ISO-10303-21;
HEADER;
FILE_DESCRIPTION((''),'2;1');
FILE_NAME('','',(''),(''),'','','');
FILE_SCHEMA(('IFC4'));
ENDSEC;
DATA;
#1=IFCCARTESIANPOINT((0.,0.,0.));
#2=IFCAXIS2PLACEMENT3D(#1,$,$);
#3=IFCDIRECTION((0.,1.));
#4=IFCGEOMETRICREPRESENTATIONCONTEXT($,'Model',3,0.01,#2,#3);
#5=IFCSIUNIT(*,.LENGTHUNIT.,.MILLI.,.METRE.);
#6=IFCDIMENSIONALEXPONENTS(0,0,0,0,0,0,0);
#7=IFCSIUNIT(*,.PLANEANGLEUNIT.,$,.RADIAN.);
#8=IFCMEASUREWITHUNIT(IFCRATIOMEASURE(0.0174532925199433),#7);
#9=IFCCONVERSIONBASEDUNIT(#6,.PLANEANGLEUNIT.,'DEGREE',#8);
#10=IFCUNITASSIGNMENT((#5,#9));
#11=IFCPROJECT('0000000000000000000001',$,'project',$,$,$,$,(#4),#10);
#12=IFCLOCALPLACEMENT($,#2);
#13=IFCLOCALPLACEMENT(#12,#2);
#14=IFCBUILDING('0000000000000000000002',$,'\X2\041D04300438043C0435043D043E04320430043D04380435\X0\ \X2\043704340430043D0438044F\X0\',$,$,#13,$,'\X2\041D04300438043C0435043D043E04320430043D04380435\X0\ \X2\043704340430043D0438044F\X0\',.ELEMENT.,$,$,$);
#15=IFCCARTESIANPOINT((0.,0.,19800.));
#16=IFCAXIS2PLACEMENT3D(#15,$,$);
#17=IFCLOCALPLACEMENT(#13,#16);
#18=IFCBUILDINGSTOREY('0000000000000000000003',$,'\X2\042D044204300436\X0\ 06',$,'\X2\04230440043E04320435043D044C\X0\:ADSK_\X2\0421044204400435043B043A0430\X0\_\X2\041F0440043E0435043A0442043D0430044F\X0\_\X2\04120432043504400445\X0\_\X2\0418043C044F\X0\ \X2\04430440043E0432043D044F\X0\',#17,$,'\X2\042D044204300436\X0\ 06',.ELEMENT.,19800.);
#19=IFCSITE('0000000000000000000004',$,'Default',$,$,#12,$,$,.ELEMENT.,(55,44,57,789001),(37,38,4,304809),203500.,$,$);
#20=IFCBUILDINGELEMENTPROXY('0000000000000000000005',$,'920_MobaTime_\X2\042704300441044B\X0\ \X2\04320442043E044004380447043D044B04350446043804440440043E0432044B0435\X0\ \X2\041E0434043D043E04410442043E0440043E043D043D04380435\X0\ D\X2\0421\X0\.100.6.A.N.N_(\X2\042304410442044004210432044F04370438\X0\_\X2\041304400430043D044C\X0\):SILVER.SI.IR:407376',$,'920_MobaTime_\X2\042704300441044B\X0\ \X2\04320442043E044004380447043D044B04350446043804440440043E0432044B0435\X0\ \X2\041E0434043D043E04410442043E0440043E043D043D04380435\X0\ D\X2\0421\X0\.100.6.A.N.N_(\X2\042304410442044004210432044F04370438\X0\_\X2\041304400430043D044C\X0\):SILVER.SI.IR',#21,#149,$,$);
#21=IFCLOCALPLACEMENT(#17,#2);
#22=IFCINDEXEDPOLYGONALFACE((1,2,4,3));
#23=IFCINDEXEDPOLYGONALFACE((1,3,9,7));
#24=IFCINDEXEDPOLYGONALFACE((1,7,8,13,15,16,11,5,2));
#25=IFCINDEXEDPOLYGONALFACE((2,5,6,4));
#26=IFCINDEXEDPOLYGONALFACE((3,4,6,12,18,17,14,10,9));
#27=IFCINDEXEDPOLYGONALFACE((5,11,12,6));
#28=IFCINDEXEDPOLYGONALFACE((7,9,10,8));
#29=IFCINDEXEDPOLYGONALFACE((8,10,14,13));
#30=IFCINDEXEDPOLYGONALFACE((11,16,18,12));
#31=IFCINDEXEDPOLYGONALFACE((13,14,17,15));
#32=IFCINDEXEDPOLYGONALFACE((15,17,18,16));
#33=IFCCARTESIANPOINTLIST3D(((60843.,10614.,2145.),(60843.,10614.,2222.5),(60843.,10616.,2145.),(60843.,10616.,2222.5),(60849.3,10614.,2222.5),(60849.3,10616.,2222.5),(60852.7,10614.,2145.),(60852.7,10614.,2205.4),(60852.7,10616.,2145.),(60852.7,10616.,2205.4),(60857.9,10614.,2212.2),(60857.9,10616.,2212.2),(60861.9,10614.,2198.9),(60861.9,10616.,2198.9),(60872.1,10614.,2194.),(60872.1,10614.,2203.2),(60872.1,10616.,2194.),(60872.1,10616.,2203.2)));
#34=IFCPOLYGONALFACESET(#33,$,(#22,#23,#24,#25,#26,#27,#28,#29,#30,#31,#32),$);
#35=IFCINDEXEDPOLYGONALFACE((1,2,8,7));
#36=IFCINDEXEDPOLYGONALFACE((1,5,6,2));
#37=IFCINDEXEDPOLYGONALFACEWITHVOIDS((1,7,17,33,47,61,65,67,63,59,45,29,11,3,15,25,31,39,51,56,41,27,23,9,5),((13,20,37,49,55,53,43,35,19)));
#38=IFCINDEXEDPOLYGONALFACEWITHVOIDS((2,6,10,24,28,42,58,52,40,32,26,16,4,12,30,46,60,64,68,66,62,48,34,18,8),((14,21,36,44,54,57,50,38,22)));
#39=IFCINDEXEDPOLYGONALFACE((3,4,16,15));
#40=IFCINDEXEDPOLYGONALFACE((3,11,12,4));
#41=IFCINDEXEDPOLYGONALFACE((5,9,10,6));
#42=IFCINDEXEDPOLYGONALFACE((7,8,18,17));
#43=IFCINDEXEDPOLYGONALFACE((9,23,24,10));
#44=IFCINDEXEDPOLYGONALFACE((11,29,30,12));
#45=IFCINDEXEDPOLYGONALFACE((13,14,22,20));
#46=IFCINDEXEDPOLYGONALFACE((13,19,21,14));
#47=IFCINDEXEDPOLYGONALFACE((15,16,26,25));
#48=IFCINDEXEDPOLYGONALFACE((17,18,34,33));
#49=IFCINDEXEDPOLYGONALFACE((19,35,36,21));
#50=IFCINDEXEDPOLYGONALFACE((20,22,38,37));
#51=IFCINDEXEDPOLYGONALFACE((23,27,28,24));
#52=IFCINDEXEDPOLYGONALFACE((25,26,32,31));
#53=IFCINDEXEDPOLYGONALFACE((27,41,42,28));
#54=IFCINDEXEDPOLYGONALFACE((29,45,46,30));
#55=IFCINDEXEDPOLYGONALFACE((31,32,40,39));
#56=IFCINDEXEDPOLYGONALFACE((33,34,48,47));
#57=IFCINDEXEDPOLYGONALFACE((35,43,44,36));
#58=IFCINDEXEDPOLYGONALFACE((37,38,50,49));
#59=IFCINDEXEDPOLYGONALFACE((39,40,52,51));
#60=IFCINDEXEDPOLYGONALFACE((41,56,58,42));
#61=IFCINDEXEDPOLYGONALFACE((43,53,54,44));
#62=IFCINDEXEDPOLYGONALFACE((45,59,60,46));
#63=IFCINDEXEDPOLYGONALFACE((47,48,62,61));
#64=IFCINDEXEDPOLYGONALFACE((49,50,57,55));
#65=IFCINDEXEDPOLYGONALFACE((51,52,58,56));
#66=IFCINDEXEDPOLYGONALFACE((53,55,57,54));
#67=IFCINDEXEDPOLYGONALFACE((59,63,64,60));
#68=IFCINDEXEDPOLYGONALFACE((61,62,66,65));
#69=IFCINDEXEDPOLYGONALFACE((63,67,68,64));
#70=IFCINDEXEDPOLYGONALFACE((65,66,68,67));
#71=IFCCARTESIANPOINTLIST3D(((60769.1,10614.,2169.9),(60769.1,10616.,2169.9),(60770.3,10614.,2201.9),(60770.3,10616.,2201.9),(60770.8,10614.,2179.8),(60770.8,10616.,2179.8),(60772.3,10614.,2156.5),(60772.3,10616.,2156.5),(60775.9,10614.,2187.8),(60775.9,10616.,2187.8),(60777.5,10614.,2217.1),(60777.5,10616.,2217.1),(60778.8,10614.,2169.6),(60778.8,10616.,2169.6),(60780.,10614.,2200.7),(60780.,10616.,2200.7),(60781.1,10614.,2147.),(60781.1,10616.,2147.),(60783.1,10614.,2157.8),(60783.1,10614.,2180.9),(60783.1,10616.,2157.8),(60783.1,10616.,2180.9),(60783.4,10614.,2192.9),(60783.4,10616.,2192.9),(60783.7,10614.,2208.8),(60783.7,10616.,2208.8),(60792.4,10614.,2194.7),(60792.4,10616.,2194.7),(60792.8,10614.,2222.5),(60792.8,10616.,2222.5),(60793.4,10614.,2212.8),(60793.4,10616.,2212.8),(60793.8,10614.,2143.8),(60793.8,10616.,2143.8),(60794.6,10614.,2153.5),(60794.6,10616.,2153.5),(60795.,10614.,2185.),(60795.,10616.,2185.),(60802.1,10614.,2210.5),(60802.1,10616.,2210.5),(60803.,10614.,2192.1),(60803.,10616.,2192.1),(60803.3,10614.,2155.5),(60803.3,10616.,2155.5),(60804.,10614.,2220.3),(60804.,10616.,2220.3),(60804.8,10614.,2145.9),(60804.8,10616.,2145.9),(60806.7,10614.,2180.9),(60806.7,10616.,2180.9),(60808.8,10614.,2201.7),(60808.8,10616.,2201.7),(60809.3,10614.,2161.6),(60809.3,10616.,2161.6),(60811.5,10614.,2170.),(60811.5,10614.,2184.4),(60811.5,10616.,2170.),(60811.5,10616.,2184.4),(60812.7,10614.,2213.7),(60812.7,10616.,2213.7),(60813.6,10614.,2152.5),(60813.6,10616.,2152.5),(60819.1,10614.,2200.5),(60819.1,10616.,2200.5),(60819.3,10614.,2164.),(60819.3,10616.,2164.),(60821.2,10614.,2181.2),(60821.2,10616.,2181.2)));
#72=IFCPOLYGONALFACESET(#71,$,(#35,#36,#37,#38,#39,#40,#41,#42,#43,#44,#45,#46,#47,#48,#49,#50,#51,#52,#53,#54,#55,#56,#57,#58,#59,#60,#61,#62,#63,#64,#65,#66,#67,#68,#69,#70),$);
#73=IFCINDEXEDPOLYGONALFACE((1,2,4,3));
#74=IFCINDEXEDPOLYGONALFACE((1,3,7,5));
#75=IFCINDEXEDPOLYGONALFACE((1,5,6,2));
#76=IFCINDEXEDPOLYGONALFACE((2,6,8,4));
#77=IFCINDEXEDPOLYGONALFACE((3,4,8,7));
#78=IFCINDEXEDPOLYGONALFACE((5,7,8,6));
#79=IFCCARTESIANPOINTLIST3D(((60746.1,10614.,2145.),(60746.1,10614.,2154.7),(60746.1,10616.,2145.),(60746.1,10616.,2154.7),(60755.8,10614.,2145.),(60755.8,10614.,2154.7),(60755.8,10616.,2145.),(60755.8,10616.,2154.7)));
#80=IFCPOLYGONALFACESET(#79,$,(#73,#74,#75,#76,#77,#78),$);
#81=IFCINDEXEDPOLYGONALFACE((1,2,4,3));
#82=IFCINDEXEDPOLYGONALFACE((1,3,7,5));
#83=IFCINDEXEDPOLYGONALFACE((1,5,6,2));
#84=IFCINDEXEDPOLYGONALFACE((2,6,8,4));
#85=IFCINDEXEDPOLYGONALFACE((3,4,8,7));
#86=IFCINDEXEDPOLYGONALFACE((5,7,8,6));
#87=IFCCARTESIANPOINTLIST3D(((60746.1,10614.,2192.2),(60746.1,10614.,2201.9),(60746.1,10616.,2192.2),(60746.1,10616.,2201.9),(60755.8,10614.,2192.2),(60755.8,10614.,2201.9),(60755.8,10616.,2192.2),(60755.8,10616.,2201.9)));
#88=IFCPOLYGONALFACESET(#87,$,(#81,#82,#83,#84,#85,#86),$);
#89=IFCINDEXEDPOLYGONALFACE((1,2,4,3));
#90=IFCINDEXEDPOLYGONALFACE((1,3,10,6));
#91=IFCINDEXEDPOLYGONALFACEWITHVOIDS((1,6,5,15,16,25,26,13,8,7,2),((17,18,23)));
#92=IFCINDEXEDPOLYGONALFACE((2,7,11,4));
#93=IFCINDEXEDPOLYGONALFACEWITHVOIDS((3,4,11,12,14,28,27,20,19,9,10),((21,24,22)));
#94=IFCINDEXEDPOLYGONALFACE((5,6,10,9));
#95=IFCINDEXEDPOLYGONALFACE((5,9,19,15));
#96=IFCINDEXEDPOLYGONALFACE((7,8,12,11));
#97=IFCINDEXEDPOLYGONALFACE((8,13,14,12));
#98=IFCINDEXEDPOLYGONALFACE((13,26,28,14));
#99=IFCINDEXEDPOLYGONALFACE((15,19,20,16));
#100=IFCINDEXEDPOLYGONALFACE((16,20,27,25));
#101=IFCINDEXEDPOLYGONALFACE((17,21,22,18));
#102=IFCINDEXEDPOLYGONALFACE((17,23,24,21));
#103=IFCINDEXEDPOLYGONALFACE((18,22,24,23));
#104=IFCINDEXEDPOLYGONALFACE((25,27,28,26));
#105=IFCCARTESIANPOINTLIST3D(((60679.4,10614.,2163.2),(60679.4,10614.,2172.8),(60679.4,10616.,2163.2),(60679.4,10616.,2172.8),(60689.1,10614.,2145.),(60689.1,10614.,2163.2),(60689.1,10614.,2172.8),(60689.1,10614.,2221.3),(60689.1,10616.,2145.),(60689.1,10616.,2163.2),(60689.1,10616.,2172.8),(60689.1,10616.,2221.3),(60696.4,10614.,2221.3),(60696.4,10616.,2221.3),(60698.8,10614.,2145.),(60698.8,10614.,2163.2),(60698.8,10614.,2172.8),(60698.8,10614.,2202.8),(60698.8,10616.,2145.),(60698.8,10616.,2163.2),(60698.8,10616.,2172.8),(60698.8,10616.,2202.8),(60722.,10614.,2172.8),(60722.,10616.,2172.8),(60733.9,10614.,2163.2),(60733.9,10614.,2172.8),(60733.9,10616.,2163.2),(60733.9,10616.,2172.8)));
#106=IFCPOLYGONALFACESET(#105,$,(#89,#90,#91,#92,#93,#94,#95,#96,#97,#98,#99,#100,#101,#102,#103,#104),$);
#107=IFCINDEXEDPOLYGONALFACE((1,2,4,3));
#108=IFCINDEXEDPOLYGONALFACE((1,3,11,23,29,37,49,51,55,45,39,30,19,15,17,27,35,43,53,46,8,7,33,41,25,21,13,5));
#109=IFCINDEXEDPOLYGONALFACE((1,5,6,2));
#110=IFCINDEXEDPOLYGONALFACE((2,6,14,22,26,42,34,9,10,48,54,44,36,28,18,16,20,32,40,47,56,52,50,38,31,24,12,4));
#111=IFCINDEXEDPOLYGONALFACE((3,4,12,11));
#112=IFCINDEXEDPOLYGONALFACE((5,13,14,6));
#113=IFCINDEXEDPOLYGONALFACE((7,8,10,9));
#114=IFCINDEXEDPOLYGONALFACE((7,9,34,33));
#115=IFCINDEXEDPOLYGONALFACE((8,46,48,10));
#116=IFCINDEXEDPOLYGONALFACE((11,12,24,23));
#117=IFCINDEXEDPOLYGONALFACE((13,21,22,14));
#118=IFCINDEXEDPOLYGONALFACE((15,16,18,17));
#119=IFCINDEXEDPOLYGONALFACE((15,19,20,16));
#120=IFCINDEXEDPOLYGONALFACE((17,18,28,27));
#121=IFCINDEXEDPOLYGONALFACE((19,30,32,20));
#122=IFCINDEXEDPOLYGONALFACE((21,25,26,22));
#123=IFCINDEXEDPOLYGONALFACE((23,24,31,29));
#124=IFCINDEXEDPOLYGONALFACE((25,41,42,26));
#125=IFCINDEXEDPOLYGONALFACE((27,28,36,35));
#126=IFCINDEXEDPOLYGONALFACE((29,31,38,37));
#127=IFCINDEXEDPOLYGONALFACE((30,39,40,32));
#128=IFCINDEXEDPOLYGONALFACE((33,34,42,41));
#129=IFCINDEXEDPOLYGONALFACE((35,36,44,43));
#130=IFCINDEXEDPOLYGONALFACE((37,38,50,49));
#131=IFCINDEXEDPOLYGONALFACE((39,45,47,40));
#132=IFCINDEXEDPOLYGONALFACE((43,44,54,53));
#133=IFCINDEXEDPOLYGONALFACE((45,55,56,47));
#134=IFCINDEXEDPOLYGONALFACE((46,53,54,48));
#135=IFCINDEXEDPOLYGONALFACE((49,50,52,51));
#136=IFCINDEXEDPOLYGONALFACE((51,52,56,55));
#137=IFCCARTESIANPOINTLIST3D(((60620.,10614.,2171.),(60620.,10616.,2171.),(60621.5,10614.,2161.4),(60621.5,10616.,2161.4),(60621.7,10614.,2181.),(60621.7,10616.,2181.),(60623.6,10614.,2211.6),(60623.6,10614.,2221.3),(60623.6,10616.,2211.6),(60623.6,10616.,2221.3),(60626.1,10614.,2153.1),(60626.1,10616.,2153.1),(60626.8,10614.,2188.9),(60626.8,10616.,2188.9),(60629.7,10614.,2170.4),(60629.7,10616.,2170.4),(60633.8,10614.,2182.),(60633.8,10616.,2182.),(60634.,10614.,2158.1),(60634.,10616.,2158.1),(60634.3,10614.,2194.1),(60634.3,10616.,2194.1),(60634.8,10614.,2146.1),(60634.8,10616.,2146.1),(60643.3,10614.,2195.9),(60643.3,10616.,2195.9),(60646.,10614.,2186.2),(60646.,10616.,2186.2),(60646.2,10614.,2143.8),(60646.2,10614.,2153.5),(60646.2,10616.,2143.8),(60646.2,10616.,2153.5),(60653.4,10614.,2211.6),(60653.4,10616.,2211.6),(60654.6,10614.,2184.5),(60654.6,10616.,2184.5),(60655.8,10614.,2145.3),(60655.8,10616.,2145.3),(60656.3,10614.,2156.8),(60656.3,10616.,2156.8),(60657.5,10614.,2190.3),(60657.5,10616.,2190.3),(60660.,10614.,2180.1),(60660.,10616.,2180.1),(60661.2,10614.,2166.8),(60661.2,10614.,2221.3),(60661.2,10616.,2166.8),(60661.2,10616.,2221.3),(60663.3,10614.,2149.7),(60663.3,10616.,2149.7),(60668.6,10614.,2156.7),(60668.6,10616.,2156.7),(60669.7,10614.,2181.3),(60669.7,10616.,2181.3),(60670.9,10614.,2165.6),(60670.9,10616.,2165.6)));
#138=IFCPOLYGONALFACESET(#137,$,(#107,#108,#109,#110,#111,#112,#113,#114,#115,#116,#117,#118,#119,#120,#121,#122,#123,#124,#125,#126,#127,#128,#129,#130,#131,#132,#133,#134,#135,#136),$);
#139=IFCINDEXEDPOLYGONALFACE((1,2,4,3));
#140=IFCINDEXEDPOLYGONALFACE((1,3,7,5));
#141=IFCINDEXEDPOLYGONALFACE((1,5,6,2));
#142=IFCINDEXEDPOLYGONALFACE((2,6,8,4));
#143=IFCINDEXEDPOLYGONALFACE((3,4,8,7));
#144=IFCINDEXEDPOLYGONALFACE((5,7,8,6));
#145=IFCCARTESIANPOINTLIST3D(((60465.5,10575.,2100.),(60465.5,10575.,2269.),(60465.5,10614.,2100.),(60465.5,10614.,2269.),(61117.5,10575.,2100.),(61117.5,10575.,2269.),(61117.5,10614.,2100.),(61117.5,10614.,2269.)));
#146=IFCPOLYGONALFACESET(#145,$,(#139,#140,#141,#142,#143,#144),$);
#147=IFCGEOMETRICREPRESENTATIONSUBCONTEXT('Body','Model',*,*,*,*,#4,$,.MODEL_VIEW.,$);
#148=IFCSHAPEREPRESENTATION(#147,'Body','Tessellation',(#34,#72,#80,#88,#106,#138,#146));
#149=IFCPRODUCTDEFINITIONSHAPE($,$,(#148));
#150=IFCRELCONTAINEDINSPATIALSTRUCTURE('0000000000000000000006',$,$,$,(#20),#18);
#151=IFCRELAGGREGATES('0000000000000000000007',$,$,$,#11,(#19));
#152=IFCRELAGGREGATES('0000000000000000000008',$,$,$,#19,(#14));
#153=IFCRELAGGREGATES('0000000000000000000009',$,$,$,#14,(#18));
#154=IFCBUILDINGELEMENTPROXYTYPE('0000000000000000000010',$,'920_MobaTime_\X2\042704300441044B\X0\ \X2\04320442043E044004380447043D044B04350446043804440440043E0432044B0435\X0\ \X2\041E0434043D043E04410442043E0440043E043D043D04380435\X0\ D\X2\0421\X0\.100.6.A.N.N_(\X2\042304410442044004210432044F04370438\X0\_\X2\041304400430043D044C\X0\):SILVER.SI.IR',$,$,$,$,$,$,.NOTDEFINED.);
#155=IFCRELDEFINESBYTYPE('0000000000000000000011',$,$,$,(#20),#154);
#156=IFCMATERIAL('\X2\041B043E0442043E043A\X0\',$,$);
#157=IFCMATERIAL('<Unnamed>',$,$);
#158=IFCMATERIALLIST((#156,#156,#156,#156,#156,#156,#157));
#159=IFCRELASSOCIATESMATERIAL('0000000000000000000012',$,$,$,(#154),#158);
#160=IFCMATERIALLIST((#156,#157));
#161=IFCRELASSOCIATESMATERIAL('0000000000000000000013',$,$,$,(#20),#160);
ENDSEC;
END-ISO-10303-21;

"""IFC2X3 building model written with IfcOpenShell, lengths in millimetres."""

from ifc_helpers import new_model, entity, si_unit, converted_unit, direction, frame, origin, origin_2d_with_axis, place, context, subcontext, project, spatial, polyline, rectangle, outline, extrude, source, transform, mapped, material, material_list, type_object, type_shapes, element, save


model = new_model("IFC2X3")

# Units and contexts
model_context = context("Model", 3, precision=0.01, world=origin(), true_north=direction((0.0, 1.0)))
body_context = subcontext(model_context, "Body", "Model", "MODEL_VIEW")
ifc_project = project(units=[si_unit("LENGTHUNIT", "METRE", prefix="MILLI"), converted_unit("PLANEANGLEUNIT", "DEGREE", entity("IfcRatioMeasure", 0.0174532925199433), si_unit("PLANEANGLEUNIT", "RADIAN"), dimensions=[0, 0, 0, 0, 0, 0, 0])], contexts=[model_context])

# Site, building, storey
site_placement = place(None, frame((0.0, 0.0, 0.0)))
site = spatial("IfcSite", under=ifc_project, at=site_placement, Name="Default", CompositionType="ELEMENT", RefLatitude=(55, 44, 57, 789001), RefLongitude=(37, 38, 4, 304809), RefElevation=203500.0)
building_placement = place(site_placement, origin())
building = spatial("IfcBuilding", under=site, at=building_placement, Name="Наименование здания", LongName="Наименование здания", CompositionType="ELEMENT")
storey_placement = place(building_placement, frame((0.0, 0.0, 19800.0)))
storey = spatial("IfcBuildingStorey", under=building, at=storey_placement, Name="Этаж 06", ObjectType="Уровень:ADSK_Стрелка_Проектная_Вверх_Имя уровня", LongName="Этаж 06", CompositionType="ELEMENT", Elevation=19800.0)

# Building element proxy
ifc_material_1 = material(Name="Лоток")
ifc_material_2 = material(Name="<Unnamed>")
ifc_material_list_1 = material_list([ifc_material_1, ifc_material_1, ifc_material_1, ifc_material_1, ifc_material_1, ifc_material_1, ifc_material_2])
building_element_proxy_type_1 = type_object("IfcBuildingElementProxyType", Name="920_MobaTime_Часы вторичныецифровые Односторонние DС.100.6.A.N.N_(УстрСвязи_Грань):SILVER.SI.IR", PredefinedType="NOTDEFINED", material=ifc_material_list_1)
shared_shape_1 = source(origin(), body_context, "Body", "SweptSolid", [
    extrude(outline(polyline([(-49.3, -13.1), (28.2, -13.1), (28.2, -6.8), (17.9, 1.8), (8.9, 16.0), (-0.3, 16.0), (4.6, 5.8), (11.1, -3.4), (-49.3, -3.4), (-49.3, -13.1)])), frame((-64.6, 9.8, 39.0), z_axis=(0.0, 0.0, 1.0), x_axis=(0.0, 1.0, 0.0)), (0.0, 0.0, 1.0), 2.0),
    extrude(outline(polyline([(2.2, -27.6), (19.0, -27.6), (30.5, -16.1), (33.3, -4.9), (31.0, 5.8), (21.8, 17.2), (5.2, 27.3), (-11.1, 33.0), (-24.0, 32.7), (-33.6, 27.6), (-40.3, 18.6), (-42.8, 5.7), (-38.0, -6.3), (-27.2, -15.0), (-17.5, -17.7), (-8.2, -16.4), (-0.3, -11.9), (5.1, -4.5), (7.3, 6.2), (4.0, 17.2), (18.5, 7.3), (23.6, -2.4), (22.0, -11.4), (14.2, -18.4), (5.3, -18.3), (2.2, -27.6)]), holes=[polyline([(-9.0, 23.3), (-1.3, 14.4), (-2.6, 2.0), (-11.4, -7.0), (-23.4, -6.1), (-32.2, 2.9), (-31.2, 15.1), (-25.6, 22.1), (-17.5, 24.9), (-9.0, 23.3)])]), frame((-2.7, 3.6, 39.0), z_axis=(0.0, 0.0, 1.0), x_axis=(-0.427649, 0.903945, 0.0)), (0.0, 0.0, 1.0), 2.0),
    extrude(rectangle(XDim=9.7, YDim=9.7, at=origin_2d_with_axis()), frame((40.6, -34.7, 39.0)), (0.0, 0.0, 1.0), 2.0),
    extrude(rectangle(XDim=9.7, YDim=9.7, at=origin_2d_with_axis()), frame((40.6, 12.6, 39.0)), (0.0, 0.0, 1.0), 2.0),
    extrude(outline(polyline([(-0.9, -28.1), (8.8, -28.1), (8.8, -9.9), (18.5, -9.9), (18.5, -0.2), (8.8, -0.2), (8.8, 48.3), (1.5, 48.3), (-36.0, -0.2), (-36.0, -9.9), (-0.9, -9.9), (-0.9, -28.1)]), holes=[polyline([(-0.9, -0.2), (-24.1, -0.2), (-0.9, 29.7), (-0.9, -0.2)])]), frame((93.6, -11.4, 39.0)), (0.0, 0.0, 1.0), 2.0),
    extrude(outline(polyline([(3.3, -28.3), (12.5, -28.3), (20.5, -25.0), (26.8, -18.8), (30.7, -10.0), (31.4, 1.6), (26.9, 11.8), (20.1, 18.4), (11.1, 22.3), (1.0, 23.3), (-7.9, 20.4), (-14.9, 14.5), (-18.9, 6.2), (-17.1, -9.0), (-36.7, 0.5), (-29.1, 29.3), (-38.5, 31.7), (-48.1, -4.6), (-11.6, -23.0), (-8.0, -14.0), (-10.8, -7.6), (-10.2, 1.1), (-3.0, 11.8), (9.2, 12.8), (20.0, 5.4), (21.3, -7.5), (15.5, -16.4), (4.6, -18.6), (3.3, -28.3)])), frame((147.1, -8.5, 39.0), z_axis=(0.0, 0.0, 1.0), x_axis=(0.256974, -0.966418, 0.0)), (0.0, 0.0, 1.0), 2.0),
    extrude(rectangle(XDim=652.0, YDim=169.0, at=origin_2d_with_axis()), frame((0.0, 0.0, 0.0), z_axis=(0.0, 0.0, 1.0), x_axis=(-1.0, 0.0, 0.0)), (0.0, 0.0, 1.0), 39.0),
])
type_shapes(building_element_proxy_type_1, [shared_shape_1])
ifc_material_list_2 = material_list([ifc_material_1, ifc_material_2])
proxy_1_placement = place(storey_placement, frame((60791.5, 10575.0, 2184.5), z_axis=(0.0, 1.0, 0.0), x_axis=(-1.0, 0.0, 0.0)))
element("IfcBuildingElementProxy", 1, at=proxy_1_placement, inside=storey, type_object=building_element_proxy_type_1, material=ifc_material_list_2, Name="920_MobaTime_Часы вторичныецифровые Односторонние DС.100.6.A.N.N_(УстрСвязи_Грань):SILVER.SI.IR:407376", ObjectType="920_MobaTime_Часы вторичныецифровые Односторонние DС.100.6.A.N.N_(УстрСвязи_Грань):SILVER.SI.IR", context=body_context, shape_type="MappedRepresentation", body=[
    mapped(shared_shape_1, transform((0.0, 0.0, 0.0), scale=1.0)),
])

save(model, "model.ifc")
